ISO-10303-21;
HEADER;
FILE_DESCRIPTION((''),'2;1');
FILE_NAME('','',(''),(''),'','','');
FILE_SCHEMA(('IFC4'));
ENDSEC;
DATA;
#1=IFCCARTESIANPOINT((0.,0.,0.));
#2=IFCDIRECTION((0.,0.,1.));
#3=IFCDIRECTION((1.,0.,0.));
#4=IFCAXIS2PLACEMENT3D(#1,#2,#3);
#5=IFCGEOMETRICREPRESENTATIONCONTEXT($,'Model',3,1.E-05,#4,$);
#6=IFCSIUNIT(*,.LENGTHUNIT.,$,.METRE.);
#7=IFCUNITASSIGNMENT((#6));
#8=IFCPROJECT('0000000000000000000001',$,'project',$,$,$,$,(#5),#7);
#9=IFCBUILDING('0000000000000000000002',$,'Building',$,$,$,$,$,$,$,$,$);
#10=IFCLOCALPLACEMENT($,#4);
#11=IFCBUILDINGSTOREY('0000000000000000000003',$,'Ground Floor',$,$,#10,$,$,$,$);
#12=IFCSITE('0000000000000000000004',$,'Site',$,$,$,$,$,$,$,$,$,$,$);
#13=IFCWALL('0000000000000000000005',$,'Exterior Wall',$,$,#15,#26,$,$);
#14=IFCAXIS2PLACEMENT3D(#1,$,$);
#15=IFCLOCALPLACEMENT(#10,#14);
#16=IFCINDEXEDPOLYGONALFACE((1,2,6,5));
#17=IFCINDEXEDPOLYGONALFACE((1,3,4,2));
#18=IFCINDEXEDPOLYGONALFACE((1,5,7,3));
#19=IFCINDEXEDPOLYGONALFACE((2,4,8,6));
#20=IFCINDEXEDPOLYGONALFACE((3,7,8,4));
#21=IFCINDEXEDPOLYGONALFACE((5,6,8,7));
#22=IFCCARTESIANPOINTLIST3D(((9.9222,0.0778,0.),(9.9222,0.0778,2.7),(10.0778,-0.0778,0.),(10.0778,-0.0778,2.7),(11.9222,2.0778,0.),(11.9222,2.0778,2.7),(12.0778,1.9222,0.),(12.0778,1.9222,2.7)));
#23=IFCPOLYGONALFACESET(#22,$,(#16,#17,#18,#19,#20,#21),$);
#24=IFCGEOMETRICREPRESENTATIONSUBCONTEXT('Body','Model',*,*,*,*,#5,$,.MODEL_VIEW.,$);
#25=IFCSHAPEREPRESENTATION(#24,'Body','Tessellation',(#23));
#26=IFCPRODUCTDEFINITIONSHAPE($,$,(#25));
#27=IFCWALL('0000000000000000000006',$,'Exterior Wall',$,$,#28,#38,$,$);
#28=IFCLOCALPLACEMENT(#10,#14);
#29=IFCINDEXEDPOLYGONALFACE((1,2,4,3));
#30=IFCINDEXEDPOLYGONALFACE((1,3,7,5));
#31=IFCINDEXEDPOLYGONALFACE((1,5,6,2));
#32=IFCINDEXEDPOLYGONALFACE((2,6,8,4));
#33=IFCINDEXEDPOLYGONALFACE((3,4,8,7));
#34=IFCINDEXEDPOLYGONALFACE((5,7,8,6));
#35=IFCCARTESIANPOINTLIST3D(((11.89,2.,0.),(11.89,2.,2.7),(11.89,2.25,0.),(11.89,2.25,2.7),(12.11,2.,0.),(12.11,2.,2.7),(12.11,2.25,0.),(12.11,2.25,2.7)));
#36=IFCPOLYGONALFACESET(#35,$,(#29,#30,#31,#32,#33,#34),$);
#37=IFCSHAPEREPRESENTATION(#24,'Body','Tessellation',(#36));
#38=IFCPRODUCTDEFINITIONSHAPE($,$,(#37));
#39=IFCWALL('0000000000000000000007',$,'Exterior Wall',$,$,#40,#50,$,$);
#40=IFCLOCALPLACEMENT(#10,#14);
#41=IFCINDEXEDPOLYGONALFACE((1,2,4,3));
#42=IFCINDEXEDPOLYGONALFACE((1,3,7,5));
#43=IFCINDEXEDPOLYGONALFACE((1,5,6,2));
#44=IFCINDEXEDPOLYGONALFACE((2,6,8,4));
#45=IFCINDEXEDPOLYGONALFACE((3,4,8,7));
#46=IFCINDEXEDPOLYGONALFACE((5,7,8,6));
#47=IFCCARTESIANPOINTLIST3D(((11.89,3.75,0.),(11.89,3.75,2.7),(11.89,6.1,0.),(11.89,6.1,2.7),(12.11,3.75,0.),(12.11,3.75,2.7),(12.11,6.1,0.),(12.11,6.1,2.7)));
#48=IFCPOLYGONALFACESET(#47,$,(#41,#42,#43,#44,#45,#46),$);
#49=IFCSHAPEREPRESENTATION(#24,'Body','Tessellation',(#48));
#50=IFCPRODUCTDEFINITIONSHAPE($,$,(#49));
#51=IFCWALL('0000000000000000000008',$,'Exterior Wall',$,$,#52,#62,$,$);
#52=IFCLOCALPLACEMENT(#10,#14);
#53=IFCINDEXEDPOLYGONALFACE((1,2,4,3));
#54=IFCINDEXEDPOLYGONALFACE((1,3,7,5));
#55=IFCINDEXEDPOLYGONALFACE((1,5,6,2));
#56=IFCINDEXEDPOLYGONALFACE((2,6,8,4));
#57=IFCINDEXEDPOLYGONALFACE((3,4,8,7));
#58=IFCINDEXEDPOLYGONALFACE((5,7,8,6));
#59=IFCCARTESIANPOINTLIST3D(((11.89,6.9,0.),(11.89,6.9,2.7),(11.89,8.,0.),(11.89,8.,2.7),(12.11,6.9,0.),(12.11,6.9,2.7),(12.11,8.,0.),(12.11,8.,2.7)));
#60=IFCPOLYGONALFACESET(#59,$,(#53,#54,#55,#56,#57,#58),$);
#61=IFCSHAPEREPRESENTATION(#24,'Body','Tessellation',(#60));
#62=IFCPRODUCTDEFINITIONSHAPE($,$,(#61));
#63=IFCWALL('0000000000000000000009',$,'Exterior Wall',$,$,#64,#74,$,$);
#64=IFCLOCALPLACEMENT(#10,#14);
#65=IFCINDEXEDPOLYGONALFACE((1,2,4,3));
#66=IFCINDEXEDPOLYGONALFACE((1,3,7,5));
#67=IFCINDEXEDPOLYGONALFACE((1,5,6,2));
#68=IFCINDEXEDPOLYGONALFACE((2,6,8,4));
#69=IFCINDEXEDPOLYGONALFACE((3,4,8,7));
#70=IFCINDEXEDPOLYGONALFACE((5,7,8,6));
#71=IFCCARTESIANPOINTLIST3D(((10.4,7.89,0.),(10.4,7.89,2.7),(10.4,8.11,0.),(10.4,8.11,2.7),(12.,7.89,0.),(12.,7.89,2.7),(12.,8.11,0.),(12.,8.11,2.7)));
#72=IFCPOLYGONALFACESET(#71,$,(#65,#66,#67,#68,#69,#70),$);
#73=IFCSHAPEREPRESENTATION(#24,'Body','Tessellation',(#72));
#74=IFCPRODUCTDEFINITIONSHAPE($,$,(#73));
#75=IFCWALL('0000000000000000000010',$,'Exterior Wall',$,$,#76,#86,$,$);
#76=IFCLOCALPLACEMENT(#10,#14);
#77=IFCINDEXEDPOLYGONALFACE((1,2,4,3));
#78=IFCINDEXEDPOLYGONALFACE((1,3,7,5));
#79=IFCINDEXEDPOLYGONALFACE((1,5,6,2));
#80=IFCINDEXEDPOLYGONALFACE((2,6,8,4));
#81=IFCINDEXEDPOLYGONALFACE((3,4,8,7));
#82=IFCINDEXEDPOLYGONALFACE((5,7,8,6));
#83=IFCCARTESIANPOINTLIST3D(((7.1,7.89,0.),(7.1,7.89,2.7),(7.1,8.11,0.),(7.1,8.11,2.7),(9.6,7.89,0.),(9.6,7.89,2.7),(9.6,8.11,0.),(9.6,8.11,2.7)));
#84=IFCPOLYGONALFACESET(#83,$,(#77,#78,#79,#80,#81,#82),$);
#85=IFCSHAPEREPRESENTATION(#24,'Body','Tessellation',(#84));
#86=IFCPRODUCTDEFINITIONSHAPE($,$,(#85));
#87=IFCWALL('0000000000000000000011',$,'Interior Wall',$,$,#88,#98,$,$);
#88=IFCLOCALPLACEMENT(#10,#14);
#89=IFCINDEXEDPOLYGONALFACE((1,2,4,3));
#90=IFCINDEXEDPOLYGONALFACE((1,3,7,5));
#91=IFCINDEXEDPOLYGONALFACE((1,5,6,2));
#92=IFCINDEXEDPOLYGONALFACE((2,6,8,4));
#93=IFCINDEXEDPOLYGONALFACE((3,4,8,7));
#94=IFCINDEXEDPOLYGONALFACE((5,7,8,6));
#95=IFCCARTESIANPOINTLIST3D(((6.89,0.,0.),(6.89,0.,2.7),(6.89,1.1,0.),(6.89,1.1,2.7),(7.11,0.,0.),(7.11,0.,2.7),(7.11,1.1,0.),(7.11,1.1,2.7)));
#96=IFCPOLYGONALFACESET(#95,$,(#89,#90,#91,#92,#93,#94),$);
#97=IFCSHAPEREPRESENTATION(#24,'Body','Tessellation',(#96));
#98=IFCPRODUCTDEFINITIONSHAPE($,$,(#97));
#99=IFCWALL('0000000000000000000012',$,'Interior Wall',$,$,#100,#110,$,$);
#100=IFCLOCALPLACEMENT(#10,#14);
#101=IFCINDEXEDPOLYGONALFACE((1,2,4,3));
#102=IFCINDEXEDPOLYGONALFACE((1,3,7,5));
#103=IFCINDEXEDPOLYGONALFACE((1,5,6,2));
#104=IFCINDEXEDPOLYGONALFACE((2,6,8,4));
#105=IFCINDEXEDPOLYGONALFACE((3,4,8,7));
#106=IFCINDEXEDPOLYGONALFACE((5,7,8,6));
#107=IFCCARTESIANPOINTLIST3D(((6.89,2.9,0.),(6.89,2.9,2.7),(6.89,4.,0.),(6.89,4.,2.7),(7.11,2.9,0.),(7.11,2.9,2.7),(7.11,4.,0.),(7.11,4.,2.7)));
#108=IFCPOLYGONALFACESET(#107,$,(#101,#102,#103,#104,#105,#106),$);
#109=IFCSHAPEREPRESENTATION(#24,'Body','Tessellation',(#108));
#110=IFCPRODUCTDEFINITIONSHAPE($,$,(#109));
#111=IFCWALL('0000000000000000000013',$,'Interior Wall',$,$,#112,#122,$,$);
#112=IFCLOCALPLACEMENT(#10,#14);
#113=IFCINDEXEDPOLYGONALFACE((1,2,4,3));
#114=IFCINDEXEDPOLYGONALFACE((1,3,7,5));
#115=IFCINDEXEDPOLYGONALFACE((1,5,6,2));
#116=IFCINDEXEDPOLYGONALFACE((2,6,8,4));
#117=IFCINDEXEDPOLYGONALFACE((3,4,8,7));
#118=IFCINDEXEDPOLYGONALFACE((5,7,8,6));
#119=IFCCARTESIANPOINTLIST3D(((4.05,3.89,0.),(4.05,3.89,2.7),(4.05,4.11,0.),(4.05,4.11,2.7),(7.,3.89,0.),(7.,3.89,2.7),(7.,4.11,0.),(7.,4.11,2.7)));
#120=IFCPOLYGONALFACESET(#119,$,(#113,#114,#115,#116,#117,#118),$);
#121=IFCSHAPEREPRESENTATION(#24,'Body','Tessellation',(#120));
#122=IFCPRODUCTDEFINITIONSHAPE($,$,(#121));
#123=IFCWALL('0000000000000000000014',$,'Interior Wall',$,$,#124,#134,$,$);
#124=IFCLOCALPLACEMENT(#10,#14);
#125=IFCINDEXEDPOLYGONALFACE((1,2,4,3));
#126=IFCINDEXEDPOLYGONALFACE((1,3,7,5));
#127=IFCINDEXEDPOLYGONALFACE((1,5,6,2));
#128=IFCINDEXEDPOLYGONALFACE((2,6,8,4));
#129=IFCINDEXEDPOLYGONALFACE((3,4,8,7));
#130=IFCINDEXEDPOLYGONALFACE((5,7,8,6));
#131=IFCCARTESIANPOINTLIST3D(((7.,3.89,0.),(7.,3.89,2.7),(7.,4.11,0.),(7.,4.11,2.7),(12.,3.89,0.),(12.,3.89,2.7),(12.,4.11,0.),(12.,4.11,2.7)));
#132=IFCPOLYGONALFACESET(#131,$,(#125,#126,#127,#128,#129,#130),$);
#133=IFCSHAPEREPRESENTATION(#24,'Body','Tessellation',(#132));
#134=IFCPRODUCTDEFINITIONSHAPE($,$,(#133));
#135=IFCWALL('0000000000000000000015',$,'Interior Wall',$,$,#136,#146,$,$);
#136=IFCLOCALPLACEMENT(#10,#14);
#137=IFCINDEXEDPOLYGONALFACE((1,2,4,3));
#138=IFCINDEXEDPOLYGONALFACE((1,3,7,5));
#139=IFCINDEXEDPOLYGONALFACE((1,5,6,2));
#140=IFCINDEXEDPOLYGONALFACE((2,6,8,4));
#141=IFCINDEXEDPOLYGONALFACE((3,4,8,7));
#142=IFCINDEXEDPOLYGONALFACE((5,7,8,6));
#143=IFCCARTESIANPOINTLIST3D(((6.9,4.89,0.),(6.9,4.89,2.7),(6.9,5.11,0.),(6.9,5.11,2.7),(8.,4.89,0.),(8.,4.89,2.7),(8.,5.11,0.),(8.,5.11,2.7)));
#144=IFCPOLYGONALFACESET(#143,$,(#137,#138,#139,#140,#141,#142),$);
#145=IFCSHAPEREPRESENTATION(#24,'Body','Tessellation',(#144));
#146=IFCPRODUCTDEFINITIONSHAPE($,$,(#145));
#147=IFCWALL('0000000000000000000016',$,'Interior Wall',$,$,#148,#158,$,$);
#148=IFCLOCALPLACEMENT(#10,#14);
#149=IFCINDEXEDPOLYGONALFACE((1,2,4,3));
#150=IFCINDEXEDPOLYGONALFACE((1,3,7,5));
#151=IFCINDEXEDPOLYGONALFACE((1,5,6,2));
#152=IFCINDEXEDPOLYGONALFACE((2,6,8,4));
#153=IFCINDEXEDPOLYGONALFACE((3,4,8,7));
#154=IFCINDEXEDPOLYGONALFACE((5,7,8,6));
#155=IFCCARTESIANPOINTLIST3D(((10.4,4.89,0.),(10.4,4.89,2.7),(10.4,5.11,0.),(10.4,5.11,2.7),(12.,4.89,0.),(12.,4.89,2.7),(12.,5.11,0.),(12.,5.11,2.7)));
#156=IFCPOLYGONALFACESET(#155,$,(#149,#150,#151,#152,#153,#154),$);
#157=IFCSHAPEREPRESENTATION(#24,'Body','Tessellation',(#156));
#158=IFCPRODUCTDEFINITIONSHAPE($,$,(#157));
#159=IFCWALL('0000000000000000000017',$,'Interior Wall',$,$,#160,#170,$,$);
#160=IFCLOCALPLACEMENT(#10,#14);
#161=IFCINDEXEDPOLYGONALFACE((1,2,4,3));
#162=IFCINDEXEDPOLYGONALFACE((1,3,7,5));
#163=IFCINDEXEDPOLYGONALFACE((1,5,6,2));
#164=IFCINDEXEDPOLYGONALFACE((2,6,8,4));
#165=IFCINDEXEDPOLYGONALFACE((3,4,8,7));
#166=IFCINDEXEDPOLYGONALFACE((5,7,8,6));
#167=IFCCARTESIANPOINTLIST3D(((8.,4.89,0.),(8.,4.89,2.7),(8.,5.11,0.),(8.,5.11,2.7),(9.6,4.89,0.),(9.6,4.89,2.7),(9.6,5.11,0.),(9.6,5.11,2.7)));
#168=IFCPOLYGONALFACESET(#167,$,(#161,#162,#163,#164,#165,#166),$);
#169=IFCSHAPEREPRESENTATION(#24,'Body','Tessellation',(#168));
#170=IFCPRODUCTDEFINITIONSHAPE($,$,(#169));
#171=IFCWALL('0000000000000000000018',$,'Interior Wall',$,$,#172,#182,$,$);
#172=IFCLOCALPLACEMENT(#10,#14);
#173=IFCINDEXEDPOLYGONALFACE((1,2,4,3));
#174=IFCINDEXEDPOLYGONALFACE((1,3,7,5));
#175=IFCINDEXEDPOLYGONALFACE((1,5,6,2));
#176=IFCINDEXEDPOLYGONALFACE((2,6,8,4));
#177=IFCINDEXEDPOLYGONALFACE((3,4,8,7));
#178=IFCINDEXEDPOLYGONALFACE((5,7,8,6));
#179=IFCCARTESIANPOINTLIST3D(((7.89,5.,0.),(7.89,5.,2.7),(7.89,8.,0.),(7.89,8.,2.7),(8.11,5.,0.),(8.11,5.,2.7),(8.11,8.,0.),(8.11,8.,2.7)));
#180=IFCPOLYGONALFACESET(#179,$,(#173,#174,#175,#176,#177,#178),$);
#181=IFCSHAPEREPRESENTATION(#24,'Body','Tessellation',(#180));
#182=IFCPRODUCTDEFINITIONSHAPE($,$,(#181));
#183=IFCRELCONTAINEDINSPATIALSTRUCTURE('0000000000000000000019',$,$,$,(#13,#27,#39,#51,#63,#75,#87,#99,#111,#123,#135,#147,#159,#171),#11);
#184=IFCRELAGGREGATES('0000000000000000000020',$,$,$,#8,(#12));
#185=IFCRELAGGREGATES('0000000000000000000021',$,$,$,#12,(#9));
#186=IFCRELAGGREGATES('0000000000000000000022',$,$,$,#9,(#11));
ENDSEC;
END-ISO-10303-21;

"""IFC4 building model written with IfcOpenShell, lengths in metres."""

from ifc_helpers import new_model, si_unit, frame, origin_with_axes, place, context, subcontext, project, spatial, indexed_curve, outline, extrude, element, save


model = new_model("IFC4")

# Units and contexts
model_context = context("Model", 3, precision=1e-05, world=origin_with_axes())
body_context = subcontext(model_context, "Body", "Model", "MODEL_VIEW")
ifc_project = project(units=[si_unit("LENGTHUNIT", "METRE")], contexts=[model_context])

# Site, building, storey
site = spatial("IfcSite", under=ifc_project, Name="Site")
building = spatial("IfcBuilding", under=site, Name="Building")
storey_placement = place(None, origin_with_axes())
storey = spatial("IfcBuildingStorey", under=building, at=storey_placement, Name="Ground Floor")

# Walls
wall_1_placement = place(storey_placement, frame((10.0, 0.0, 0.0), z_axis=(0.0, 0.0, 1.0), x_axis=(0.707107, 0.707107, 0.0)))
element("IfcWall", 1, at=wall_1_placement, inside=storey, Name="Exterior Wall", context=body_context, shape_type="SweptSolid", body=[
    extrude(outline(indexed_curve([(0.0, 0.0), (0.0, 0.22), (2.8284, 0.22), (2.8284, 0.0), (0.0, 0.0)], self_intersect=False)), frame((0.0, -0.11, 0.0), z_axis=(0.0, 0.0, 1.0), x_axis=(1.0, 0.0, 0.0)), (0.0, 0.0, 1.0), 2.7),
])
wall_2_placement = place(storey_placement, frame((12.0, 2.0, 0.0), z_axis=(0.0, 0.0, 1.0), x_axis=(0.0, 1.0, 0.0)))
element("IfcWall", 2, at=wall_2_placement, inside=storey, Name="Exterior Wall", context=body_context, shape_type="SweptSolid", body=[
    extrude(outline(indexed_curve([(0.0, 0.0), (0.0, 0.22), (0.25, 0.22), (0.25, 0.0), (0.0, 0.0)], self_intersect=False)), frame((0.0, -0.11, 0.0), z_axis=(0.0, 0.0, 1.0), x_axis=(1.0, 0.0, 0.0)), (0.0, 0.0, 1.0), 2.7),
])
wall_3_placement = place(storey_placement, frame((12.0, 3.75, 0.0), z_axis=(0.0, 0.0, 1.0), x_axis=(0.0, 1.0, 0.0)))
element("IfcWall", 3, at=wall_3_placement, inside=storey, Name="Exterior Wall", context=body_context, shape_type="SweptSolid", body=[
    extrude(outline(indexed_curve([(0.0, 0.0), (0.0, 0.22), (2.35, 0.22), (2.35, 0.0), (0.0, 0.0)], self_intersect=False)), frame((0.0, -0.11, 0.0), z_axis=(0.0, 0.0, 1.0), x_axis=(1.0, 0.0, 0.0)), (0.0, 0.0, 1.0), 2.7),
])
wall_4_placement = place(storey_placement, frame((12.0, 6.9, 0.0), z_axis=(0.0, 0.0, 1.0), x_axis=(0.0, 1.0, 0.0)))
element("IfcWall", 4, at=wall_4_placement, inside=storey, Name="Exterior Wall", context=body_context, shape_type="SweptSolid", body=[
    extrude(outline(indexed_curve([(0.0, 0.0), (0.0, 0.22), (1.1, 0.22), (1.1, 0.0), (0.0, 0.0)], self_intersect=False)), frame((0.0, -0.11, 0.0), z_axis=(0.0, 0.0, 1.0), x_axis=(1.0, 0.0, 0.0)), (0.0, 0.0, 1.0), 2.7),
])
wall_5_placement = place(storey_placement, frame((12.0, 8.0, 0.0), z_axis=(0.0, 0.0, 1.0), x_axis=(-1.0, 0.0, 0.0)))
element("IfcWall", 5, at=wall_5_placement, inside=storey, Name="Exterior Wall", context=body_context, shape_type="SweptSolid", body=[
    extrude(outline(indexed_curve([(0.0, 0.0), (0.0, 0.22), (1.6, 0.22), (1.6, 0.0), (0.0, 0.0)], self_intersect=False)), frame((0.0, -0.11, 0.0), z_axis=(0.0, 0.0, 1.0), x_axis=(1.0, 0.0, 0.0)), (0.0, 0.0, 1.0), 2.7),
])
wall_6_placement = place(storey_placement, frame((9.6, 8.0, 0.0), z_axis=(0.0, 0.0, 1.0), x_axis=(-1.0, 0.0, 0.0)))
element("IfcWall", 6, at=wall_6_placement, inside=storey, Name="Exterior Wall", context=body_context, shape_type="SweptSolid", body=[
    extrude(outline(indexed_curve([(0.0, 0.0), (0.0, 0.22), (2.5, 0.22), (2.5, 0.0), (0.0, 0.0)], self_intersect=False)), frame((0.0, -0.11, 0.0), z_axis=(0.0, 0.0, 1.0), x_axis=(1.0, 0.0, 0.0)), (0.0, 0.0, 1.0), 2.7),
])
for number, where, z_axis, x_axis, name in (
    (7, (7.0, 0.0, 0.0), (0.0, 0.0, 1.0), (0.0, 1.0, 0.0), "Interior Wall"),
    (8, (7.0, 2.9, 0.0), (0.0, 0.0, 1.0), (0.0, 1.0, 0.0), "Interior Wall"),
):
    element("IfcWall", number, at=place(storey_placement, frame(where, z_axis=z_axis, x_axis=x_axis)), inside=storey, Name=name, context=body_context, shape_type="SweptSolid", body=[
        extrude(outline(indexed_curve([(0.0, 0.0), (0.0, 0.22), (1.1, 0.22), (1.1, 0.0), (0.0, 0.0)], self_intersect=False)), frame((0.0, -0.11, 0.0), z_axis=(0.0, 0.0, 1.0), x_axis=(1.0, 0.0, 0.0)), (0.0, 0.0, 1.0), 2.7),
    ])
wall_7_placement = place(storey_placement, frame((7.0, 4.0, 0.0), z_axis=(0.0, 0.0, 1.0), x_axis=(-1.0, 0.0, 0.0)))
element("IfcWall", 9, at=wall_7_placement, inside=storey, Name="Interior Wall", context=body_context, shape_type="SweptSolid", body=[
    extrude(outline(indexed_curve([(0.0, 0.0), (0.0, 0.22), (2.95, 0.22), (2.95, 0.0), (0.0, 0.0)], self_intersect=False)), frame((0.0, -0.11, 0.0), z_axis=(0.0, 0.0, 1.0), x_axis=(1.0, 0.0, 0.0)), (0.0, 0.0, 1.0), 2.7),
])
wall_8_placement = place(storey_placement, frame((12.0, 4.0, 0.0), z_axis=(0.0, 0.0, 1.0), x_axis=(-1.0, 0.0, 0.0)))
element("IfcWall", 10, at=wall_8_placement, inside=storey, Name="Interior Wall", context=body_context, shape_type="SweptSolid", body=[
    extrude(outline(indexed_curve([(0.0, 0.0), (0.0, 0.22), (5.0, 0.22), (5.0, 0.0), (0.0, 0.0)], self_intersect=False)), frame((0.0, -0.11, 0.0), z_axis=(0.0, 0.0, 1.0), x_axis=(1.0, 0.0, 0.0)), (0.0, 0.0, 1.0), 2.7),
])
wall_9_placement = place(storey_placement, frame((8.0, 5.0, 0.0), z_axis=(0.0, 0.0, 1.0), x_axis=(-1.0, 0.0, 0.0)))
element("IfcWall", 11, at=wall_9_placement, inside=storey, Name="Interior Wall", context=body_context, shape_type="SweptSolid", body=[
    extrude(outline(indexed_curve([(0.0, 0.0), (0.0, 0.22), (1.1, 0.22), (1.1, 0.0), (0.0, 0.0)], self_intersect=False)), frame((0.0, -0.11, 0.0), z_axis=(0.0, 0.0, 1.0), x_axis=(1.0, 0.0, 0.0)), (0.0, 0.0, 1.0), 2.7),
])
for number, where, z_axis, x_axis, name in (
    (12, (12.0, 5.0, 0.0), (0.0, 0.0, 1.0), (-1.0, 0.0, 0.0), "Interior Wall"),
    (13, (9.6, 5.0, 0.0), (0.0, 0.0, 1.0), (-1.0, 0.0, 0.0), "Interior Wall"),
):
    element("IfcWall", number, at=place(storey_placement, frame(where, z_axis=z_axis, x_axis=x_axis)), inside=storey, Name=name, context=body_context, shape_type="SweptSolid", body=[
        extrude(outline(indexed_curve([(0.0, 0.0), (0.0, 0.22), (1.6, 0.22), (1.6, 0.0), (0.0, 0.0)], self_intersect=False)), frame((0.0, -0.11, 0.0), z_axis=(0.0, 0.0, 1.0), x_axis=(1.0, 0.0, 0.0)), (0.0, 0.0, 1.0), 2.7),
    ])
wall_10_placement = place(storey_placement, frame((8.0, 5.0, 0.0), z_axis=(0.0, 0.0, 1.0), x_axis=(0.0, 1.0, 0.0)))
element("IfcWall", 14, at=wall_10_placement, inside=storey, Name="Interior Wall", context=body_context, shape_type="SweptSolid", body=[
    extrude(outline(indexed_curve([(0.0, 0.0), (0.0, 0.22), (3.0, 0.22), (3.0, 0.0), (0.0, 0.0)], self_intersect=False)), frame((0.0, -0.11, 0.0), z_axis=(0.0, 0.0, 1.0), x_axis=(1.0, 0.0, 0.0)), (0.0, 0.0, 1.0), 2.7),
])

save(model, "model.ifc")
